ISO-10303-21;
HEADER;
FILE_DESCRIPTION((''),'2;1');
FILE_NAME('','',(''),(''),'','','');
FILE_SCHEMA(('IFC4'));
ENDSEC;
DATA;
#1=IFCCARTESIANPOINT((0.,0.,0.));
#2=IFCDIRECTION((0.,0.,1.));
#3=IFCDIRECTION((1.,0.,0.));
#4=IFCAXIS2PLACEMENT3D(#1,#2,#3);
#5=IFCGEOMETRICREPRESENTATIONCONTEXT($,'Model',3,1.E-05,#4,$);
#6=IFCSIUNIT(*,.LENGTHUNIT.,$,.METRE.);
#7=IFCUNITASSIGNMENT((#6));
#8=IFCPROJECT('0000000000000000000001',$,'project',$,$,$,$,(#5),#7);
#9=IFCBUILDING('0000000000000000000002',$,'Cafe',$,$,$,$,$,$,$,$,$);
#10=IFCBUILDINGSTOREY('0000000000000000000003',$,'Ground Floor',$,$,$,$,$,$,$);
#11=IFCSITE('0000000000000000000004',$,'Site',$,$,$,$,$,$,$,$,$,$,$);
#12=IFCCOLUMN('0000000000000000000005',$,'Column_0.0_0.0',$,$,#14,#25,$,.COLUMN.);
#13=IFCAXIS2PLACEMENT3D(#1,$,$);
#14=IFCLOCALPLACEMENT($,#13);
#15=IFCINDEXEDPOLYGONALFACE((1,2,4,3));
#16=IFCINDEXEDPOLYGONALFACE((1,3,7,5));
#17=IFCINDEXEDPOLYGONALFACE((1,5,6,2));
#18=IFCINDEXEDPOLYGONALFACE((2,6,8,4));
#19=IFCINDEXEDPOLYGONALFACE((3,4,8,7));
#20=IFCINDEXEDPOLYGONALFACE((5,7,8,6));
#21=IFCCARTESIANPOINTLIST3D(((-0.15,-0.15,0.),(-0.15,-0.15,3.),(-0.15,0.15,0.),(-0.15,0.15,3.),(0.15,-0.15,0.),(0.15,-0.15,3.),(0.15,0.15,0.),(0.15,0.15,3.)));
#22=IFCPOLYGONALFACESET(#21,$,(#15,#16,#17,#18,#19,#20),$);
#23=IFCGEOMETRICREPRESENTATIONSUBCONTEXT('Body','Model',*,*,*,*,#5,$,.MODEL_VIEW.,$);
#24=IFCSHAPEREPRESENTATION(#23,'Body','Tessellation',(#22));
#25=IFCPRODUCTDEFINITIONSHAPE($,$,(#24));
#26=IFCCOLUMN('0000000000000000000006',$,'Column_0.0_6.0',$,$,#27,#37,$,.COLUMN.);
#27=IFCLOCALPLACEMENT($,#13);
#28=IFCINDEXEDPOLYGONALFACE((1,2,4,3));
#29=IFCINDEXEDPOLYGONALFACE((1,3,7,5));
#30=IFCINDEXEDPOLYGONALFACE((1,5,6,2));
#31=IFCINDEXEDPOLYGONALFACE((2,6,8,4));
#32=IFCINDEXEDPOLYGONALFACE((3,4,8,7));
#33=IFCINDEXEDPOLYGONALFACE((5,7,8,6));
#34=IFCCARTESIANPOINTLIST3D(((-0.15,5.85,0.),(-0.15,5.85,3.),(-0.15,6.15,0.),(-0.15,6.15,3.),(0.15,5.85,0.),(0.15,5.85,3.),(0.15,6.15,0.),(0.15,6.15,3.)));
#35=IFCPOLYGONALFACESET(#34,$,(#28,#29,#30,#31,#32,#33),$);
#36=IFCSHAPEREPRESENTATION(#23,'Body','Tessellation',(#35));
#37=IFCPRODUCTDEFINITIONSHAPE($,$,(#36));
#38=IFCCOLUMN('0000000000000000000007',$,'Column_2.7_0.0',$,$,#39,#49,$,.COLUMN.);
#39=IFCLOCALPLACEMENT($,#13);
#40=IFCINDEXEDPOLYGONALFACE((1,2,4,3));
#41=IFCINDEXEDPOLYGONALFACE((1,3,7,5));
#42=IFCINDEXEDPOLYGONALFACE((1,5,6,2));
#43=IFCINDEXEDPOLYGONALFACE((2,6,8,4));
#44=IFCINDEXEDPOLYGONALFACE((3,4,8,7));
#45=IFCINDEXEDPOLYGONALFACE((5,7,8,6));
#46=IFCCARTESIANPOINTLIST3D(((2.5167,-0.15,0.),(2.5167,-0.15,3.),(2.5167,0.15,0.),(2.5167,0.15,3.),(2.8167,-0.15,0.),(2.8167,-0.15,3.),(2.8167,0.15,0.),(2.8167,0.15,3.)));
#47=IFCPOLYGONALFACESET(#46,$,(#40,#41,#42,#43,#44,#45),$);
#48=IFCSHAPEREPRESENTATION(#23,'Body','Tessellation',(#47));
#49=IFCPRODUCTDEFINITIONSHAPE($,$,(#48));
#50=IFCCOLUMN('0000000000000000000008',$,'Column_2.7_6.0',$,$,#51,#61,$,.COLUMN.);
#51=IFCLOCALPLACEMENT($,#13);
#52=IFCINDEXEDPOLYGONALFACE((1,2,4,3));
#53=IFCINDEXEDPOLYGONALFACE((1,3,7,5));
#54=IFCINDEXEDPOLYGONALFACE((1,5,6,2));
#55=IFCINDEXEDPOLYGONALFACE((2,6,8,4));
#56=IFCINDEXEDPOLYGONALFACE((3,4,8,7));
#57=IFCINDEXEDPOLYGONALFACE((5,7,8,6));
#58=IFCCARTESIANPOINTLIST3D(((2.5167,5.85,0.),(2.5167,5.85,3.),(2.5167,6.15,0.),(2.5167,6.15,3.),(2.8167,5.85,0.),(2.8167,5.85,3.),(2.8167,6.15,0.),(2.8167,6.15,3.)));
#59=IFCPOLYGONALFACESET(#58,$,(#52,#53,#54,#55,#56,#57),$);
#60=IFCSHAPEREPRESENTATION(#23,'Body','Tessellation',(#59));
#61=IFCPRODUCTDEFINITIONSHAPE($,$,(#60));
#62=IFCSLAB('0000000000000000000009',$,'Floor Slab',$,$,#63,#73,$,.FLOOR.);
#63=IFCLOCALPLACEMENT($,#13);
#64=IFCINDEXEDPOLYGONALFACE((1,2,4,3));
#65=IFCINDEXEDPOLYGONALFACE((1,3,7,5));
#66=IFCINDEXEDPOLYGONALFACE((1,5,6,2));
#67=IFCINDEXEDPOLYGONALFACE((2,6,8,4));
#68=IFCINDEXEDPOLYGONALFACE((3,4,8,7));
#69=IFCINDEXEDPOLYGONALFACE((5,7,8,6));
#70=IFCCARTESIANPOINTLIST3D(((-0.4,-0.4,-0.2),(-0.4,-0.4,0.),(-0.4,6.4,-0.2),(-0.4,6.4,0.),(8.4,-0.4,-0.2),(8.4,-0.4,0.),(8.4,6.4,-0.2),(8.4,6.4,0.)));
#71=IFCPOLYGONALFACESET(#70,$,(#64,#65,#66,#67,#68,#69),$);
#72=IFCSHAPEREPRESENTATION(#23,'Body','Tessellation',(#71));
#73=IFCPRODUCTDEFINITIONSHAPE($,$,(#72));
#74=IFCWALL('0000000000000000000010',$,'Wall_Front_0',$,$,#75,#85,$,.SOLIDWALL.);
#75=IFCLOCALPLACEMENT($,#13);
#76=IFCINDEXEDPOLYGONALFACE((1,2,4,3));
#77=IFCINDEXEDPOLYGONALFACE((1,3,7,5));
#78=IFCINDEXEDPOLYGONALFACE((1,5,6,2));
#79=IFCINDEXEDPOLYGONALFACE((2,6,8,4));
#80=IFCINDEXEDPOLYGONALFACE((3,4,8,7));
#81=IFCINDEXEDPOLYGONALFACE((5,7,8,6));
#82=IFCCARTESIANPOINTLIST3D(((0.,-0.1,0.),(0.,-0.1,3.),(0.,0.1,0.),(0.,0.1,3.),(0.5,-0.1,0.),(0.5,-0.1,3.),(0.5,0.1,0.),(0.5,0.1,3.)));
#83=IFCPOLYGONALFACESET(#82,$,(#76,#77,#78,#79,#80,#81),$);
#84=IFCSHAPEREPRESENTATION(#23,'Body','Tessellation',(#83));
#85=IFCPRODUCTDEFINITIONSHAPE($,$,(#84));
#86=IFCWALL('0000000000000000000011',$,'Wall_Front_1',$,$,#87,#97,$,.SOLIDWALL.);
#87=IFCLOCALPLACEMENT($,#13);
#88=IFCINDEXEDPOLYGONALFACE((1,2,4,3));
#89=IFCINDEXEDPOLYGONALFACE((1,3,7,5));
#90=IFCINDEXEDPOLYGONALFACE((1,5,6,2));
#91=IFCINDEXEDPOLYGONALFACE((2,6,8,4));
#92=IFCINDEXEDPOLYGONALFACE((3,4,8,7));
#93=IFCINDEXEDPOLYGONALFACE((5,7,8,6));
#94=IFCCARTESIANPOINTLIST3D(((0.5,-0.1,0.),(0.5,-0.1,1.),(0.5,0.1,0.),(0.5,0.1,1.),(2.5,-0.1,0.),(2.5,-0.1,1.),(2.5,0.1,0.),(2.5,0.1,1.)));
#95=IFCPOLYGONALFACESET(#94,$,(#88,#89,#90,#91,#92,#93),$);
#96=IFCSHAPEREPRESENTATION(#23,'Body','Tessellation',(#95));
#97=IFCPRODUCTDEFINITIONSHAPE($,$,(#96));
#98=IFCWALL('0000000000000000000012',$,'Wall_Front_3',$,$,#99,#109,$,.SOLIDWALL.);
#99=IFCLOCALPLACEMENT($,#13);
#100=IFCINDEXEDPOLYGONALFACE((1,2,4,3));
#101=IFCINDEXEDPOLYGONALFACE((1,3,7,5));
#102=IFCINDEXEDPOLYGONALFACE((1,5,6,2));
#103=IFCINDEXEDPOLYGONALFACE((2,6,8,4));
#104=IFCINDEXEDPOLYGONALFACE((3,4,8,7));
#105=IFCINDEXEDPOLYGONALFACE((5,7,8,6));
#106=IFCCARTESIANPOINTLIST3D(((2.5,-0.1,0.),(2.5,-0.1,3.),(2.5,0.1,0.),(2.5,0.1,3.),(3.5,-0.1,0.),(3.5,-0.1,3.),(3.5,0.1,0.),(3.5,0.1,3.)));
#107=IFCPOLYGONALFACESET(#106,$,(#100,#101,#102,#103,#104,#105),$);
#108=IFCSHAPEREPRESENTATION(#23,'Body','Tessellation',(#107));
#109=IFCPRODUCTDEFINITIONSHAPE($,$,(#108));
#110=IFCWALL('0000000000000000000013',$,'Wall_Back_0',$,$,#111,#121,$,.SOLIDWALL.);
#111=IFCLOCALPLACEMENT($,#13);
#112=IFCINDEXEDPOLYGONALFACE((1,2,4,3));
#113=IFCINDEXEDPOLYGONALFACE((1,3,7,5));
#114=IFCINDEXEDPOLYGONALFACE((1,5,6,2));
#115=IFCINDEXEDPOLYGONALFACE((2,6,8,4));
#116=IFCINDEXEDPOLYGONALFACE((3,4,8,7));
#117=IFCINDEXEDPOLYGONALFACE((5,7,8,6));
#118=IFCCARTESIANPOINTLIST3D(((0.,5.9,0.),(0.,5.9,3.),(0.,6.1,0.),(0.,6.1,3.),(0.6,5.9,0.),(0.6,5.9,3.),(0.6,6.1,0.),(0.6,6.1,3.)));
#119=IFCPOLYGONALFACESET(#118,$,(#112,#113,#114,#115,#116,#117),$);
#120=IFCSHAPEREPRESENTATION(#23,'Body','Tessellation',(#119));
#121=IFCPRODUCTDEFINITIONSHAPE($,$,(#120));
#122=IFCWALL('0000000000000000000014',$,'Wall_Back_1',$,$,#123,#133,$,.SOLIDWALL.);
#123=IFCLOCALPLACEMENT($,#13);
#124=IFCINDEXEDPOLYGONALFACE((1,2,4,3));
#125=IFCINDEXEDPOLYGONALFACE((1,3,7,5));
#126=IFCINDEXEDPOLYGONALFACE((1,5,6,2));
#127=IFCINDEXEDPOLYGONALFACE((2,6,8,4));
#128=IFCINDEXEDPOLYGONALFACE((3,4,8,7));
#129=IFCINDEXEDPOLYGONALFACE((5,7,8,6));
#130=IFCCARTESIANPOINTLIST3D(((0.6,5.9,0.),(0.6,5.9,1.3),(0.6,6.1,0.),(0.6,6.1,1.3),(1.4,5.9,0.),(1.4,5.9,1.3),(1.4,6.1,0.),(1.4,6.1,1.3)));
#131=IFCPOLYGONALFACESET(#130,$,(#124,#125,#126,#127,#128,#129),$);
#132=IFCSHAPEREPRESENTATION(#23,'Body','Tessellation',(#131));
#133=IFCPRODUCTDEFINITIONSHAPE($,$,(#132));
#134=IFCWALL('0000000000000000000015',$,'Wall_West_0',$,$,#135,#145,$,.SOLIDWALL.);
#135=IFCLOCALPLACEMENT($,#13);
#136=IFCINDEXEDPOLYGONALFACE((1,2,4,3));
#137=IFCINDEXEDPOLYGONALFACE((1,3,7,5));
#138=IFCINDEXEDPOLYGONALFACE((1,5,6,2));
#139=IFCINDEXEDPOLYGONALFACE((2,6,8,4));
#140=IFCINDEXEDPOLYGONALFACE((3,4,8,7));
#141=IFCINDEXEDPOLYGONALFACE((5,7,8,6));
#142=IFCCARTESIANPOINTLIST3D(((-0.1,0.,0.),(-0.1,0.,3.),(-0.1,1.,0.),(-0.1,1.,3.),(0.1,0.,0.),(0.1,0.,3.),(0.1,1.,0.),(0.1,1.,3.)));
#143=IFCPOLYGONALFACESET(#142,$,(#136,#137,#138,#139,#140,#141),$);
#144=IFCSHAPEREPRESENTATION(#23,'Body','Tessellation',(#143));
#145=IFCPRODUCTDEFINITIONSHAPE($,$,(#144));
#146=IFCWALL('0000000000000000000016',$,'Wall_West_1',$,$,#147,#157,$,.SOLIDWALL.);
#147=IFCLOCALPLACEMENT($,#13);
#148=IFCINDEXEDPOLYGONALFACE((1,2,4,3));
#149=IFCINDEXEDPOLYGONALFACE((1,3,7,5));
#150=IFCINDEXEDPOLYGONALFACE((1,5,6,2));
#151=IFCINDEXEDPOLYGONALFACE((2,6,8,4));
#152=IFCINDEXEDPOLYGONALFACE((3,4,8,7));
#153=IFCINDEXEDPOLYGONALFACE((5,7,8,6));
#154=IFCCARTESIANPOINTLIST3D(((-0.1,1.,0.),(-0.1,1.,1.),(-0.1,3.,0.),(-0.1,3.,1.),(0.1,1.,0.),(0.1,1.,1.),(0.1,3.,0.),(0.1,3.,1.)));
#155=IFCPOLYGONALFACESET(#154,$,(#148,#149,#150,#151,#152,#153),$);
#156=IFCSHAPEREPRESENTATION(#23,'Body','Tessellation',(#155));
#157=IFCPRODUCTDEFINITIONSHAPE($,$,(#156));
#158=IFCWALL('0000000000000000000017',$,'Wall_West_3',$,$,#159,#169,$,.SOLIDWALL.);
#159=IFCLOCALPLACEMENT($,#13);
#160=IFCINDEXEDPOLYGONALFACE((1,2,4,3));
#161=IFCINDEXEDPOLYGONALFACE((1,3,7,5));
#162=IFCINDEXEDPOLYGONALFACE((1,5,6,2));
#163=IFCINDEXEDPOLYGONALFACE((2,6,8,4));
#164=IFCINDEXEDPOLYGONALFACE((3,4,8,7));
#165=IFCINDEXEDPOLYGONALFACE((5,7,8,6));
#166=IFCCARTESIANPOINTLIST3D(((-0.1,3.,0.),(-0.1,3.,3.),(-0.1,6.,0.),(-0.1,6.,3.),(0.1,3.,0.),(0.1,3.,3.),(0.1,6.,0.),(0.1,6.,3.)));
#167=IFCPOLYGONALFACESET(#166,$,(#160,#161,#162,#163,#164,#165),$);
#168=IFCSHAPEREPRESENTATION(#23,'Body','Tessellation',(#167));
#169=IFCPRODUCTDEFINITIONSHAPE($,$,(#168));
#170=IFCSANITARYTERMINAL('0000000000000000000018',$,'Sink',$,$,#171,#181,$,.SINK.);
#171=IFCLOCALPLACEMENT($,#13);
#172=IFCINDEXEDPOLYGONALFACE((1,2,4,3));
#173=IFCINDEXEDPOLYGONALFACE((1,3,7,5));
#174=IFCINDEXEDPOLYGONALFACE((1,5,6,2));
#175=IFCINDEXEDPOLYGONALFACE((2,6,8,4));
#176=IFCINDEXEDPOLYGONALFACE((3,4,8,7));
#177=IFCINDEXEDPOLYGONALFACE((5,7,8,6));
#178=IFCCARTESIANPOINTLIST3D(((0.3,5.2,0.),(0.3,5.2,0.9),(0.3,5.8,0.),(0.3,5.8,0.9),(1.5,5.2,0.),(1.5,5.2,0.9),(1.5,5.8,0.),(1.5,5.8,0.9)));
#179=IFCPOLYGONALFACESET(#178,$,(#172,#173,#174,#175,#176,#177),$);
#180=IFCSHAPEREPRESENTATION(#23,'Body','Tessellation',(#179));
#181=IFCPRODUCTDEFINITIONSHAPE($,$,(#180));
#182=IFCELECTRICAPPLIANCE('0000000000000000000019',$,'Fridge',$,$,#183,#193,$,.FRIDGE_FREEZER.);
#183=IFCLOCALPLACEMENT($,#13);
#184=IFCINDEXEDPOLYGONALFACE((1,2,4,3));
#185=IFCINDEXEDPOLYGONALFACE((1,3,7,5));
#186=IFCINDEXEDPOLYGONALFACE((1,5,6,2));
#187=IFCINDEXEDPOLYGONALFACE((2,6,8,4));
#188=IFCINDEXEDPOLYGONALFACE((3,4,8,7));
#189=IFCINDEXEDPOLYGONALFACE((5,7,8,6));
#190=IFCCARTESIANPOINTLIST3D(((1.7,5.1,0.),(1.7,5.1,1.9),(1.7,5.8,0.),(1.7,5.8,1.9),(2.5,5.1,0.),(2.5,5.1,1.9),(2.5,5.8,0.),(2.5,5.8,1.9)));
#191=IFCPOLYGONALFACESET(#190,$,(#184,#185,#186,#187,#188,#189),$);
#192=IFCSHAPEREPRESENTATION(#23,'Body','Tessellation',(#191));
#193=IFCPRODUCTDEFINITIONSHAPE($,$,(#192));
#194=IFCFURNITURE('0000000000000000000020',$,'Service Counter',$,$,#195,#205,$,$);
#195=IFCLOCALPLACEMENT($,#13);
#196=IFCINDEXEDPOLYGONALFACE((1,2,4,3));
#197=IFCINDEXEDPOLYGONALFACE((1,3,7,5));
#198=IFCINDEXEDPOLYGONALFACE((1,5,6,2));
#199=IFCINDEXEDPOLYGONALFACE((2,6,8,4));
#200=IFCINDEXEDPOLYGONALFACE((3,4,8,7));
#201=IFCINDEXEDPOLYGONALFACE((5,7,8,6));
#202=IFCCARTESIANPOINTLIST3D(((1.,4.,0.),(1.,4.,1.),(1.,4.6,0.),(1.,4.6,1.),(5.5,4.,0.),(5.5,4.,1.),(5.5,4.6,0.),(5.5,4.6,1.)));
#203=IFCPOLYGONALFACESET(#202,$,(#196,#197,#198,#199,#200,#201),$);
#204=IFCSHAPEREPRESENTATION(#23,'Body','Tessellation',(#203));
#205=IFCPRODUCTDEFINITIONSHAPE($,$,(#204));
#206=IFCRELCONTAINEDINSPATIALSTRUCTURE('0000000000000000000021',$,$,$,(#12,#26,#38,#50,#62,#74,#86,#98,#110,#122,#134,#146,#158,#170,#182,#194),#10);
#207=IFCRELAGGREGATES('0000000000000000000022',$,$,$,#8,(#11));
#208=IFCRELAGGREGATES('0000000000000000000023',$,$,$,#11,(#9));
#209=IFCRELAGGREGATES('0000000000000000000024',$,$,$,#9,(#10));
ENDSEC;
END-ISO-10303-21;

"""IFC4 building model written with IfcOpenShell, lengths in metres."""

from ifc_helpers import new_model, si_unit, frame, origin, origin_with_axes, origin_2d, place, context, subcontext, project, spatial, rectangle, extrude, element, save


model = new_model("IFC4")

# Units and contexts
model_context = context("Model", 3, precision=1e-05, world=origin_with_axes())
body_context = subcontext(model_context, "Body", "Model", "MODEL_VIEW")
ifc_project = project(units=[si_unit("LENGTHUNIT", "METRE")], contexts=[model_context])

# Site, building, storey
site = spatial("IfcSite", under=ifc_project, Name="Site")
building = spatial("IfcBuilding", under=site, Name="Cafe")
storey = spatial("IfcBuildingStorey", under=building, Name="Ground Floor")

# Columns
column_1_placement = place(None, origin_with_axes())
element("IfcColumn", 1, at=column_1_placement, inside=storey, Name="Column_0.0_0.0", PredefinedType="COLUMN", context=body_context, shape_type="SweptSolid", body=[
    extrude(rectangle(XDim=0.3, YDim=0.3, at=origin_2d()), origin(), (0.0, 0.0, 1.0), 3.0),
])
column_2_placement = place(None, frame((0.0, 6.0, 0.0), z_axis=(0.0, 0.0, 1.0), x_axis=(1.0, 0.0, 0.0)))
element("IfcColumn", 2, at=column_2_placement, inside=storey, Name="Column_0.0_6.0", PredefinedType="COLUMN", context=body_context, shape_type="SweptSolid", body=[
    extrude(rectangle(XDim=0.3, YDim=0.3, at=origin_2d()), origin(), (0.0, 0.0, 1.0), 3.0),
])
column_3_placement = place(None, frame((2.6667, 0.0, 0.0), z_axis=(0.0, 0.0, 1.0), x_axis=(1.0, 0.0, 0.0)))
element("IfcColumn", 3, at=column_3_placement, inside=storey, Name="Column_2.7_0.0", PredefinedType="COLUMN", context=body_context, shape_type="SweptSolid", body=[
    extrude(rectangle(XDim=0.3, YDim=0.3, at=origin_2d()), origin(), (0.0, 0.0, 1.0), 3.0),
])
column_4_placement = place(None, frame((2.6667, 6.0, 0.0), z_axis=(0.0, 0.0, 1.0), x_axis=(1.0, 0.0, 0.0)))
element("IfcColumn", 4, at=column_4_placement, inside=storey, Name="Column_2.7_6.0", PredefinedType="COLUMN", context=body_context, shape_type="SweptSolid", body=[
    extrude(rectangle(XDim=0.3, YDim=0.3, at=origin_2d()), origin(), (0.0, 0.0, 1.0), 3.0),
])

# Slab
slab_placement = place(None, frame((4.0, 3.0, -0.2), z_axis=(0.0, 0.0, 1.0), x_axis=(1.0, 0.0, 0.0)))
element("IfcSlab", 5, at=slab_placement, inside=storey, Name="Floor Slab", PredefinedType="FLOOR", context=body_context, shape_type="SweptSolid", body=[
    extrude(rectangle(XDim=8.8, YDim=6.8, at=origin_2d()), origin(), (0.0, 0.0, 1.0), 0.2),
])

# Walls
wall_1_placement = place(None, frame((0.25, 0.0, 0.0), z_axis=(0.0, 0.0, 1.0), x_axis=(1.0, 0.0, 0.0)))
element("IfcWall", 6, at=wall_1_placement, inside=storey, Name="Wall_Front_0", PredefinedType="SOLIDWALL", context=body_context, shape_type="SweptSolid", body=[
    extrude(rectangle(XDim=0.5, YDim=0.2, at=origin_2d()), origin(), (0.0, 0.0, 1.0), 3.0),
])
wall_2_placement = place(None, frame((1.5, 0.0, 0.0), z_axis=(0.0, 0.0, 1.0), x_axis=(1.0, 0.0, 0.0)))
element("IfcWall", 7, at=wall_2_placement, inside=storey, Name="Wall_Front_1", PredefinedType="SOLIDWALL", context=body_context, shape_type="SweptSolid", body=[
    extrude(rectangle(XDim=2.0, YDim=0.2, at=origin_2d()), origin(), (0.0, 0.0, 1.0), 1.0),
])
wall_3_placement = place(None, frame((3.0, 0.0, 0.0), z_axis=(0.0, 0.0, 1.0), x_axis=(1.0, 0.0, 0.0)))
element("IfcWall", 8, at=wall_3_placement, inside=storey, Name="Wall_Front_3", PredefinedType="SOLIDWALL", context=body_context, shape_type="SweptSolid", body=[
    extrude(rectangle(XDim=1.0, YDim=0.2, at=origin_2d()), origin(), (0.0, 0.0, 1.0), 3.0),
])
wall_4_placement = place(None, frame((0.3, 6.0, 0.0), z_axis=(0.0, 0.0, 1.0), x_axis=(1.0, 0.0, 0.0)))
element("IfcWall", 9, at=wall_4_placement, inside=storey, Name="Wall_Back_0", PredefinedType="SOLIDWALL", context=body_context, shape_type="SweptSolid", body=[
    extrude(rectangle(XDim=0.6, YDim=0.2, at=origin_2d()), origin(), (0.0, 0.0, 1.0), 3.0),
])
wall_5_placement = place(None, frame((1.0, 6.0, 0.0), z_axis=(0.0, 0.0, 1.0), x_axis=(1.0, 0.0, 0.0)))
element("IfcWall", 10, at=wall_5_placement, inside=storey, Name="Wall_Back_1", PredefinedType="SOLIDWALL", context=body_context, shape_type="SweptSolid", body=[
    extrude(rectangle(XDim=0.8, YDim=0.2, at=origin_2d()), origin(), (0.0, 0.0, 1.0), 1.3),
])
wall_6_placement = place(None, frame((0.0, 0.5, 0.0), z_axis=(0.0, 0.0, 1.0), x_axis=(1.0, 0.0, 0.0)))
element("IfcWall", 11, at=wall_6_placement, inside=storey, Name="Wall_West_0", PredefinedType="SOLIDWALL", context=body_context, shape_type="SweptSolid", body=[
    extrude(rectangle(XDim=0.2, YDim=1.0, at=origin_2d()), origin(), (0.0, 0.0, 1.0), 3.0),
])
wall_7_placement = place(None, frame((0.0, 2.0, 0.0), z_axis=(0.0, 0.0, 1.0), x_axis=(1.0, 0.0, 0.0)))
element("IfcWall", 12, at=wall_7_placement, inside=storey, Name="Wall_West_1", PredefinedType="SOLIDWALL", context=body_context, shape_type="SweptSolid", body=[
    extrude(rectangle(XDim=0.2, YDim=2.0, at=origin_2d()), origin(), (0.0, 0.0, 1.0), 1.0),
])
wall_8_placement = place(None, frame((0.0, 4.5, 0.0), z_axis=(0.0, 0.0, 1.0), x_axis=(1.0, 0.0, 0.0)))
element("IfcWall", 13, at=wall_8_placement, inside=storey, Name="Wall_West_3", PredefinedType="SOLIDWALL", context=body_context, shape_type="SweptSolid", body=[
    extrude(rectangle(XDim=0.2, YDim=3.0, at=origin_2d()), origin(), (0.0, 0.0, 1.0), 3.0),
])

# Sanitary terminal
sanitary_terminal_placement = place(None, frame((0.9, 5.5, 0.0), z_axis=(0.0, 0.0, 1.0), x_axis=(1.0, 0.0, 0.0)))
element("IfcSanitaryTerminal", 14, at=sanitary_terminal_placement, inside=storey, Name="Sink", PredefinedType="SINK", context=body_context, shape_type="SweptSolid", body=[
    extrude(rectangle(XDim=1.2, YDim=0.6, at=origin_2d()), origin(), (0.0, 0.0, 1.0), 0.9),
])

# Electric appliance
electric_appliance_placement = place(None, frame((2.1, 5.45, 0.0), z_axis=(0.0, 0.0, 1.0), x_axis=(1.0, 0.0, 0.0)))
element("IfcElectricAppliance", 15, at=electric_appliance_placement, inside=storey, Name="Fridge", PredefinedType="FRIDGE_FREEZER", context=body_context, shape_type="SweptSolid", body=[
    extrude(rectangle(XDim=0.8, YDim=0.7, at=origin_2d()), origin(), (0.0, 0.0, 1.0), 1.9),
])

# Furniture
furniture_1_placement = place(None, frame((3.25, 4.3, 0.0), z_axis=(0.0, 0.0, 1.0), x_axis=(1.0, 0.0, 0.0)))
element("IfcFurniture", 16, at=furniture_1_placement, inside=storey, Name="Service Counter", context=body_context, shape_type="SweptSolid", body=[
    extrude(rectangle(XDim=4.5, YDim=0.6, at=origin_2d()), origin(), (0.0, 0.0, 1.0), 1.0),
])

save(model, "model.ifc")
